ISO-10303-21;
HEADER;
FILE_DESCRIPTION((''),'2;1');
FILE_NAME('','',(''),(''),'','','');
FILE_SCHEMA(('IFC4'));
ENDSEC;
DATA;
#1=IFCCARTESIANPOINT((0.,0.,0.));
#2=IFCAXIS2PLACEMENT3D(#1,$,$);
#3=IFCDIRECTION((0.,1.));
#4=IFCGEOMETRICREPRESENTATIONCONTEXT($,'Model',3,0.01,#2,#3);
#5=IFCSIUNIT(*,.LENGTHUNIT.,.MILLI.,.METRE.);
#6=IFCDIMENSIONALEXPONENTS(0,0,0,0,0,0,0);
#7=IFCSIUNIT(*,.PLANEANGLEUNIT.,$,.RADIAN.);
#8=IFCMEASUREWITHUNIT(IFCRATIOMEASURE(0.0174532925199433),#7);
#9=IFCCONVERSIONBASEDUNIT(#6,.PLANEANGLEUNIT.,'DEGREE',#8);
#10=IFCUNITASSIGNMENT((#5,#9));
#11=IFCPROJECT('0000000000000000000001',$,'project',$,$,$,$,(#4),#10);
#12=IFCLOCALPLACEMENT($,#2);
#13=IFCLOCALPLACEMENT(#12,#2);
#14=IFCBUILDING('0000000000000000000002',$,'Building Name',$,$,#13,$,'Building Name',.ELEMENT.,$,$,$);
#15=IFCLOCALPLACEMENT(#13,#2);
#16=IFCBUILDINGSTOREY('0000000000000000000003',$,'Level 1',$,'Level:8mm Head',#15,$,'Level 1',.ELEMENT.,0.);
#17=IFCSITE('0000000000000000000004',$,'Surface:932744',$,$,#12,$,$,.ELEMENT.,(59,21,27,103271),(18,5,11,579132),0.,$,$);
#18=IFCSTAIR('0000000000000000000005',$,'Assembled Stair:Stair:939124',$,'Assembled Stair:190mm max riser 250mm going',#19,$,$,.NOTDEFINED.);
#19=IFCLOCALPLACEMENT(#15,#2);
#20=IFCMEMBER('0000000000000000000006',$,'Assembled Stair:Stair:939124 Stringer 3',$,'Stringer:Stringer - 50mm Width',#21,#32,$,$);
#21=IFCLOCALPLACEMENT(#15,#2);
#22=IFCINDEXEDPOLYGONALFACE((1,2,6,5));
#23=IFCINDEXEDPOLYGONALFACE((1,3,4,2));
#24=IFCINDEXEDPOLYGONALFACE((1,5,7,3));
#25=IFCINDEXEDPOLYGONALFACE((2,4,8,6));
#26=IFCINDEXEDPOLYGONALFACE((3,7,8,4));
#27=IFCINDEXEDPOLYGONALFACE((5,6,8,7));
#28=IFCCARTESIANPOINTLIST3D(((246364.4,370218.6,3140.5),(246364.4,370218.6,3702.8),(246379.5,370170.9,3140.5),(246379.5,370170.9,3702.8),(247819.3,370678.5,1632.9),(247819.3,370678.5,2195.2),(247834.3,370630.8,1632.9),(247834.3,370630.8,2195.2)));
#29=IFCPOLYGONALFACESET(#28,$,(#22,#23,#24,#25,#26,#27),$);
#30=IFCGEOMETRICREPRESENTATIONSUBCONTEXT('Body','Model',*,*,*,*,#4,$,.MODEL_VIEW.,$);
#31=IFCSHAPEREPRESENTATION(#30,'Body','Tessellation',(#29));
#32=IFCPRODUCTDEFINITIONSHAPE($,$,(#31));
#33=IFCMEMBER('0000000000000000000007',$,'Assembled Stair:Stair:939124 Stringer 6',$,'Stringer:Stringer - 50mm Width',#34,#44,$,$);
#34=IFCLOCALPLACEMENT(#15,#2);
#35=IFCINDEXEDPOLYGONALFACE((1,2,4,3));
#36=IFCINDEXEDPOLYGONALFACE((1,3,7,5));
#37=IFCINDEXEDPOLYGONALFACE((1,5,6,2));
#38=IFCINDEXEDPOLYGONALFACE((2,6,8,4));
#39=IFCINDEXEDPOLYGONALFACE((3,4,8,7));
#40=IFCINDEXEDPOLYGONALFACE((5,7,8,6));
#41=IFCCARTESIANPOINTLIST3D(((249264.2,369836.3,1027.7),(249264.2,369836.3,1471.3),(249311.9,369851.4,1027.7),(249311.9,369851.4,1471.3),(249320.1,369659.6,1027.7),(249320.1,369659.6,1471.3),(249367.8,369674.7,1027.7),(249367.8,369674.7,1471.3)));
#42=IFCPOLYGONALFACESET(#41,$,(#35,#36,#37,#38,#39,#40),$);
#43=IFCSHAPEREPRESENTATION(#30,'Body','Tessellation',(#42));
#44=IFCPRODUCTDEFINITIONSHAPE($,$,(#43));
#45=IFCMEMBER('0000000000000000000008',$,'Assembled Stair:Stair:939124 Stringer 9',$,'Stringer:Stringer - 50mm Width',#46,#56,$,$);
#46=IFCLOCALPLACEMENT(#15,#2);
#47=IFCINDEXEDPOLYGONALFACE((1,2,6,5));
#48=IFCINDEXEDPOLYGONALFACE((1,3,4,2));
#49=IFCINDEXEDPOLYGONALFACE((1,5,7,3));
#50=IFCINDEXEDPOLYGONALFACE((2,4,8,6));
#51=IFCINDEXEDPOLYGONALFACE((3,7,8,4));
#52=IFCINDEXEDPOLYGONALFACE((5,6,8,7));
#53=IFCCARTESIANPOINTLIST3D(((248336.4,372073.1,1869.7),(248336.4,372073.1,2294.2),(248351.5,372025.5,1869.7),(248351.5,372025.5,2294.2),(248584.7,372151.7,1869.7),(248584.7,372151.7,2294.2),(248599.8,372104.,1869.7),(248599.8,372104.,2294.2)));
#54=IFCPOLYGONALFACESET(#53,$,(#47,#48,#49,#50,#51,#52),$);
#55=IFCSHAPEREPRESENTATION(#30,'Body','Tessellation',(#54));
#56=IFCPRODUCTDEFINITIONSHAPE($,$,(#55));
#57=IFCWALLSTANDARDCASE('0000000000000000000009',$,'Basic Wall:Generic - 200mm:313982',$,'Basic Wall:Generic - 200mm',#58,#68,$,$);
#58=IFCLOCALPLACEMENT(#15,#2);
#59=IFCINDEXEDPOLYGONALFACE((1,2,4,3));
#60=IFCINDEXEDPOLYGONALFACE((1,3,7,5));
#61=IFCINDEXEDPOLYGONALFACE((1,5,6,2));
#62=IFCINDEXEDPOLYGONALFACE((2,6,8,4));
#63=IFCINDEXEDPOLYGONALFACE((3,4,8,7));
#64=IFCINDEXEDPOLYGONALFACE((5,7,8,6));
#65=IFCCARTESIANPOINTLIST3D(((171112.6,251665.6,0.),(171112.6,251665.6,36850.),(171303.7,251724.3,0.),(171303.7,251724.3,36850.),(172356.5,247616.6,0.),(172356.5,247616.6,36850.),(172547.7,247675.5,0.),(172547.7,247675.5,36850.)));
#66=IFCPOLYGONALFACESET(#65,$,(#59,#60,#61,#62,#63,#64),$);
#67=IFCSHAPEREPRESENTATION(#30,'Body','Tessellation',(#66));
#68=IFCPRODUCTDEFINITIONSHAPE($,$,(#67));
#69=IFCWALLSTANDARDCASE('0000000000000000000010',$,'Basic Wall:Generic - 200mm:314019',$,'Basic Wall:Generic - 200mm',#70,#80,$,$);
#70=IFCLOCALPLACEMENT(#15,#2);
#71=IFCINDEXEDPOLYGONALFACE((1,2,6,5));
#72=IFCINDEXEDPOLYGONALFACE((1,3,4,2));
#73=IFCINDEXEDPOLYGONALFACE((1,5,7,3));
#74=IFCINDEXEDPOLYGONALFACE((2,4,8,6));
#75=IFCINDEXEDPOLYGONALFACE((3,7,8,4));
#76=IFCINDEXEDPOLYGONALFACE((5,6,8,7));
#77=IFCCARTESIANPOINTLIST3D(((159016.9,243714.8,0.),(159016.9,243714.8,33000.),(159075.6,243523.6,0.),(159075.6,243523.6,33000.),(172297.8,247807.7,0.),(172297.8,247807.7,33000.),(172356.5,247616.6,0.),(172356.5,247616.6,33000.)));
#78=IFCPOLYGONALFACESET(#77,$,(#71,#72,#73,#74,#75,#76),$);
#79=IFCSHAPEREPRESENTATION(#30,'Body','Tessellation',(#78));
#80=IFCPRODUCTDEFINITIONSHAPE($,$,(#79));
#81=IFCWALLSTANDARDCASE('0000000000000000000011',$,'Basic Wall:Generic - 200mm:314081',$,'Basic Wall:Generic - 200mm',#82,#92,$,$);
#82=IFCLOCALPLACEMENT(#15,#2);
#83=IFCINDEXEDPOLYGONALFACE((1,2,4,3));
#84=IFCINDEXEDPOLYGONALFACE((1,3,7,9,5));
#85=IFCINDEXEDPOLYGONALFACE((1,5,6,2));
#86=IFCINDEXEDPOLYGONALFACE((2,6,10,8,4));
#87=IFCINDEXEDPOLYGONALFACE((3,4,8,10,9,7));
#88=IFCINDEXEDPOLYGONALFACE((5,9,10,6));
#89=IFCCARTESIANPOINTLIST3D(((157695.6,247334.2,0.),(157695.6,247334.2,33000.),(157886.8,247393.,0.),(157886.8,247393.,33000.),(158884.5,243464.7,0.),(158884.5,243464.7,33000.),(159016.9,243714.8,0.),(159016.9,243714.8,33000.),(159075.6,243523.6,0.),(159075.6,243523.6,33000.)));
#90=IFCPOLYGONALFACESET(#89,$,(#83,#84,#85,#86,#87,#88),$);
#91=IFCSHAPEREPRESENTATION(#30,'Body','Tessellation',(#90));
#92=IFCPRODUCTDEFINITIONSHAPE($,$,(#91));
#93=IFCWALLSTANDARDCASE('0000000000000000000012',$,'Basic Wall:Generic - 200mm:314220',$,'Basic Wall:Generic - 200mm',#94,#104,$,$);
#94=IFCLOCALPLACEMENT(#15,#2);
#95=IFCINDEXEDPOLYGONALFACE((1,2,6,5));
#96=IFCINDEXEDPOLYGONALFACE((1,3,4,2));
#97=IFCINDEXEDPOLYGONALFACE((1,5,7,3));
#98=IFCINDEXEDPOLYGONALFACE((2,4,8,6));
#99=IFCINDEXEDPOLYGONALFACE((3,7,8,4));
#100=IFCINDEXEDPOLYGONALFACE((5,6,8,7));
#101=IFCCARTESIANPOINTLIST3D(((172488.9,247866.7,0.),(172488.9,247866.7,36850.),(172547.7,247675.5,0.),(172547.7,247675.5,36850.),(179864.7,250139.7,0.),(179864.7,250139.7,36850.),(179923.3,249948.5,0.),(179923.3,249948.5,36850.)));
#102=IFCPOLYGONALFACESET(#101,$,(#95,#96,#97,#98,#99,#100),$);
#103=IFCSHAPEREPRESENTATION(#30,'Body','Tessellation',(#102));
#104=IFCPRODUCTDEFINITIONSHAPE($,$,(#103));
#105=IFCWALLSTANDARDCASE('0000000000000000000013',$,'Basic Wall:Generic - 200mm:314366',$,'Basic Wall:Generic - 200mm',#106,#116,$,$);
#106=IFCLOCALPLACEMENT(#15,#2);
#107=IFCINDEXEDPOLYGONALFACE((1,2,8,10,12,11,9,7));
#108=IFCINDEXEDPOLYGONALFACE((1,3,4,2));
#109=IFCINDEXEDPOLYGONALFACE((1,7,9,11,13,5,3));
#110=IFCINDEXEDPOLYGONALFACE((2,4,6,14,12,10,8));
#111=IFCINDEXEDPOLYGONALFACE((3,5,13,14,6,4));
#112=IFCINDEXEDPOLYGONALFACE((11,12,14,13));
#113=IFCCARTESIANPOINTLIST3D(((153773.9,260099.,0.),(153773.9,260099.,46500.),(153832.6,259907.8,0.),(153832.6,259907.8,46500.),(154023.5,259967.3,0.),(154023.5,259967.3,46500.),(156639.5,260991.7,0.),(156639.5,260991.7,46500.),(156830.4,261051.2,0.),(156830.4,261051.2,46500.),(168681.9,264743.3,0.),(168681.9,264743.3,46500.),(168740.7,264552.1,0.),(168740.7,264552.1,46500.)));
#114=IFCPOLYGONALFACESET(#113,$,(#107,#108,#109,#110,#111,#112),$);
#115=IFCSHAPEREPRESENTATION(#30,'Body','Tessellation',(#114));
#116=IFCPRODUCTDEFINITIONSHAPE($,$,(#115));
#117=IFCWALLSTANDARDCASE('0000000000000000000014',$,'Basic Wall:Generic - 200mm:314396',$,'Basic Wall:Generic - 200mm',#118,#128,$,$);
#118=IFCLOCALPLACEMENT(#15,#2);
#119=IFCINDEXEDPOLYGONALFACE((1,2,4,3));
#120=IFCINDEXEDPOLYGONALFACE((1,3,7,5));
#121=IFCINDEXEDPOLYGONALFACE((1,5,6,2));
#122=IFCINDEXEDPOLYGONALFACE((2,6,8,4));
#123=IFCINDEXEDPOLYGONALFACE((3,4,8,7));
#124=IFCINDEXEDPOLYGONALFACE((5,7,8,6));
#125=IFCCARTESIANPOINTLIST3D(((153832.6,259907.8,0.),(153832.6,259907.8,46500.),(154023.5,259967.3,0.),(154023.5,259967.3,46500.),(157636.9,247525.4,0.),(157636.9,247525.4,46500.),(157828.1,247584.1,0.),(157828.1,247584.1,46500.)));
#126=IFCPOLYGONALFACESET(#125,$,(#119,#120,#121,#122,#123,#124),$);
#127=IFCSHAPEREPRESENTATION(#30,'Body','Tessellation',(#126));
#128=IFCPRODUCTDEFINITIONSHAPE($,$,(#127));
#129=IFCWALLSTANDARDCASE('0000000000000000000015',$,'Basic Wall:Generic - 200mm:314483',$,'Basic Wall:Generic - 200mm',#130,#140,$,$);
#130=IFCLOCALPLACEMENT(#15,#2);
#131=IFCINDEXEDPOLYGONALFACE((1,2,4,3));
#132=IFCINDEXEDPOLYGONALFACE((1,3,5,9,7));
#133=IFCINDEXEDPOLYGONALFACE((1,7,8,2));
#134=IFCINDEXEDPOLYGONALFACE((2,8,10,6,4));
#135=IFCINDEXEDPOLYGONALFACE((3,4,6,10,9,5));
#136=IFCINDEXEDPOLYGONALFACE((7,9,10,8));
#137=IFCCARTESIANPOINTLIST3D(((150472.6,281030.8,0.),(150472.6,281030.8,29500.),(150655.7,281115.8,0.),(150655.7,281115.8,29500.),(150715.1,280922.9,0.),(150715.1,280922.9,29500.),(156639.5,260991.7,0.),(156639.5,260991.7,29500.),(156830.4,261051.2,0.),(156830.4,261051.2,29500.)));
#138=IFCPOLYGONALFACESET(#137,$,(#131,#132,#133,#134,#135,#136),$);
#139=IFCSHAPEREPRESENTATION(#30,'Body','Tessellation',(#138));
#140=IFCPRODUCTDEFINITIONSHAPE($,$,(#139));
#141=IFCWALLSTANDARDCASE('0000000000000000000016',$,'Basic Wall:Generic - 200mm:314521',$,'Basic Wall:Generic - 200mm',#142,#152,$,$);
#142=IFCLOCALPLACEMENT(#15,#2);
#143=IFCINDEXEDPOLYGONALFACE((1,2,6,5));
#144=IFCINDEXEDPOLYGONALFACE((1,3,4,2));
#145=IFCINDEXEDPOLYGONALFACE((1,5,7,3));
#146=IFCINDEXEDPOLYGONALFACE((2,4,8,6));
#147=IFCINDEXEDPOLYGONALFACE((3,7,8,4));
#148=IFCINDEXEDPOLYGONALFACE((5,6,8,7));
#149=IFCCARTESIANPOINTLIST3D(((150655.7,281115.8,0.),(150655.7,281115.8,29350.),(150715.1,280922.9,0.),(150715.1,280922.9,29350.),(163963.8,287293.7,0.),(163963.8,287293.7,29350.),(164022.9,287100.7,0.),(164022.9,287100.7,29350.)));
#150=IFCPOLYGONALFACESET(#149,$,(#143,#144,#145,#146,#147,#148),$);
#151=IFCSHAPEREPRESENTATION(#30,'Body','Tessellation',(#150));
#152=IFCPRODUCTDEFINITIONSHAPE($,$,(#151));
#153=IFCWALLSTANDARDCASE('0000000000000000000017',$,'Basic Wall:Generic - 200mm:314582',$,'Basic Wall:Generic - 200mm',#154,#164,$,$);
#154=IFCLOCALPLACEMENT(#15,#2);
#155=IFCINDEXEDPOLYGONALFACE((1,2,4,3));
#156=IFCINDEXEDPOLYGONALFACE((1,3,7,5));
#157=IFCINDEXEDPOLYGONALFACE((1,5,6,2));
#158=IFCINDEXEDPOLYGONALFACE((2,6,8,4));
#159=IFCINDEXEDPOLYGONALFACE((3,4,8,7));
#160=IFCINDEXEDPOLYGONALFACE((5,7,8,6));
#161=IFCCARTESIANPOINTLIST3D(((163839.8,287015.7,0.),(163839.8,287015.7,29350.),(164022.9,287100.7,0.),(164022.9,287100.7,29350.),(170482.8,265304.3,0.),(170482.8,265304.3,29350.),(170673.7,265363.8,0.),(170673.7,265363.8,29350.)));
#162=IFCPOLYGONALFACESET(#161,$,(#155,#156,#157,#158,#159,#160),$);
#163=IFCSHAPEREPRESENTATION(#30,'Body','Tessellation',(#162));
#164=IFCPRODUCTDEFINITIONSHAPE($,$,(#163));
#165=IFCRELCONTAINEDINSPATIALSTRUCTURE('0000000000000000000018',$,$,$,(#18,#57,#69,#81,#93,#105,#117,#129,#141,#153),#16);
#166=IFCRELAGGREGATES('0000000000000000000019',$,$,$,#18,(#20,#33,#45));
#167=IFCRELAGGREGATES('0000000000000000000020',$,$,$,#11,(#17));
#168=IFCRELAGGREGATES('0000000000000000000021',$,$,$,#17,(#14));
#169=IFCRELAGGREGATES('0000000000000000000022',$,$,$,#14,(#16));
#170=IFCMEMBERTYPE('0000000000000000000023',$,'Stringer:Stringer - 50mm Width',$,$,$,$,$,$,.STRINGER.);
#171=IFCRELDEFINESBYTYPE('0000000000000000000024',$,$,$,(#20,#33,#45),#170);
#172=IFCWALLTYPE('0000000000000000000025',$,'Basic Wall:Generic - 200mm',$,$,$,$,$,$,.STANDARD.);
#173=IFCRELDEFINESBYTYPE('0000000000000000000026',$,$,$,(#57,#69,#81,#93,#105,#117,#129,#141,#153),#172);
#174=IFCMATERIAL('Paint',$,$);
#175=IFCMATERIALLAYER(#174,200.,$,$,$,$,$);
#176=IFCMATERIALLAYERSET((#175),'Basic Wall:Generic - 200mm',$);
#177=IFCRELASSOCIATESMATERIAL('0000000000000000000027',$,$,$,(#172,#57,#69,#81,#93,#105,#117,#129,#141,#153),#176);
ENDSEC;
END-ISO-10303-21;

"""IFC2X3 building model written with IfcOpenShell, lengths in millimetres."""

from ifc_helpers import new_model, entity, si_unit, converted_unit, direction, frame, frame_2d, origin, place, context, subcontext, project, spatial, polyline, rectangle, outline, extrude, clip, bounded_halfspace, material, layer, layer_set, layer_usage, type_object, element, aggregate, save


model = new_model("IFC2X3")

# Units and contexts
model_context = context("Model", 3, precision=0.01, world=origin(), true_north=direction((0.0, 1.0)))
body_context = subcontext(model_context, "Body", "Model", "MODEL_VIEW")
ifc_project = project(units=[si_unit("LENGTHUNIT", "METRE", prefix="MILLI"), converted_unit("PLANEANGLEUNIT", "DEGREE", entity("IfcRatioMeasure", 0.0174532925199433), si_unit("PLANEANGLEUNIT", "RADIAN"), dimensions=[0, 0, 0, 0, 0, 0, 0])], contexts=[model_context])

# Site, building, storey
site_placement = place(None, origin())
site = spatial("IfcSite", under=ifc_project, at=site_placement, Name="Surface:932744", CompositionType="ELEMENT", RefLatitude=(59, 21, 27, 103271), RefLongitude=(18, 5, 11, 579132), RefElevation=0.0)
building_placement = place(site_placement, origin())
building = spatial("IfcBuilding", under=site, at=building_placement, Name="Building Name", LongName="Building Name", CompositionType="ELEMENT")
storey_placement = place(building_placement, origin())
storey = spatial("IfcBuildingStorey", under=building, at=storey_placement, Name="Level 1", ObjectType="Level:8mm Head", LongName="Level 1", CompositionType="ELEMENT", Elevation=0.0)

# Stair, members
stair_placement = place(building_placement, origin())
stair = element("IfcStair", 1, at=stair_placement, inside=storey, Name="Assembled Stair:Stair:939124", ObjectType="Assembled Stair:190mm max riser 250mm going", ShapeType="NOTDEFINED")
member_type = type_object("IfcMemberType", Name="Stringer:Stringer - 50mm Width", PredefinedType="STRINGER")
member_1_placement = place(stair_placement, origin())
member_1 = element("IfcMember", 2, at=member_1_placement, type_object=member_type, Name="Assembled Stair:Stair:939124 Stringer 3", ObjectType="Stringer:Stringer - 50mm Width", context=body_context, shape_type="SweptSolid", body=[
    extrude(outline(polyline([(-1270.1, -200.0), (874.9, -200.0), (1270.1, 200.0), (-874.9, 200.0), (-1270.1, -200.0)])), frame((247106.9, 370400.9, 2667.8), z_axis=(-0.301424, 0.95349, 0.0), x_axis=(-0.678262, -0.214417, 0.702841)), (0.0, 0.0, 1.0), 50.0),
])
member_2_placement = place(stair_placement, origin())
member_2 = element("IfcMember", 3, at=member_2_placement, type_object=member_type, Name="Assembled Stair:Stair:939124 Stringer 6", ObjectType="Stringer:Stringer - 50mm Width", context=body_context, shape_type="SweptSolid", body=[
    extrude(rectangle(XDim=185.4, YDim=50.0, at=frame_2d((0.0, 0.0), x_axis=(1.0, 0.0))), frame((249316.0, 369755.5, 1027.7), z_axis=(0.0, 0.0, 1.0), x_axis=(-0.301424, 0.95349, 0.0)), (0.0, 0.0, 1.0), 443.6),
])
member_3_placement = place(stair_placement, origin())
member_3 = element("IfcMember", 4, at=member_3_placement, type_object=member_type, Name="Assembled Stair:Stair:939124 Stringer 9", ObjectType="Stringer:Stringer - 50mm Width", context=body_context, shape_type="SweptSolid", body=[
    extrude(rectangle(XDim=260.5, YDim=50.0, at=frame_2d((0.0, 0.0), x_axis=(1.0, 0.0))), frame((248468.1, 372088.6, 1869.7), z_axis=(0.0, 0.0, 1.0), x_axis=(-0.95349, -0.301424, 0.0)), (0.0, 0.0, 1.0), 424.5),
])

# Walls
ifc_material_1 = material(Name="Paint")
ifc_layer_1 = layer(ifc_material_1, 200.0)
ifc_layer_set_1 = layer_set([ifc_layer_1], Name="Basic Wall:Generic - 200mm")
wall_type = type_object("IfcWallType", Name="Basic Wall:Generic - 200mm", PredefinedType="STANDARD", material=ifc_layer_set_1)
ifc_layer_usage_1 = layer_usage(ifc_layer_set_1, "AXIS2", "NEGATIVE", 100.0)
wall_1_placement = place(storey_placement, frame((171208.1, 251694.9, 0.0), z_axis=(0.0, 0.0, 1.0), x_axis=(0.293685, -0.955902, 0.0)))
element("IfcWallStandardCase", 5, at=wall_1_placement, inside=storey, type_object=wall_type, material=ifc_layer_usage_1, Name="Basic Wall:Generic - 200mm:313982", ObjectType="Basic Wall:Generic - 200mm", context=body_context, shape_type="Clipping", body=[
    clip(extrude(outline(polyline([(4235.8, -100.0), (4235.6, 100.0), (4035.6, 100.0), (200.0, 100.0), (0.0, 100.0), (0.0, -100.0), (200.0, -100.0), (4035.8, -100.0), (4235.8, -100.0)])), origin(), (0.0, 0.0, 1.0), 36850.0), bounded_halfspace(frame((0.0, -100.0, 36850.0), z_axis=(0.0, 0.0, -1.0), x_axis=(-1.0, 0.0, 0.0)), True, frame((0.0, -100.0, 36850.0), z_axis=(0.0, 0.0, -1.0), x_axis=(-1.0, 0.0, 0.0)), polyline([(0.0, 0.0), (0.0, 200.0), (-200.0, 200.0), (-4035.6, 200.0), (-4235.6, 200.0), (-4235.8, 0.0), (0.0, 0.0)]))),
])
ifc_layer_usage_2 = layer_usage(ifc_layer_set_1, "AXIS2", "NEGATIVE", 100.0)
wall_2_placement = place(storey_placement, frame((159046.2, 243619.2, 0.0), z_axis=(0.0, 0.0, 1.0), x_axis=(0.955647, 0.294515, 0.0)))
element("IfcWallStandardCase", 6, at=wall_2_placement, inside=storey, type_object=wall_type, material=ifc_layer_usage_2, Name="Basic Wall:Generic - 200mm:314019", ObjectType="Basic Wall:Generic - 200mm", context=body_context, shape_type="SweptSolid", body=[
    extrude(outline(polyline([(13897.3, -100.0), (13897.5, 100.0), (0.2, 100.0), (0.0, -100.0), (13897.3, -100.0)])), origin(), (0.0, 0.0, 1.0), 33000.0),
])
ifc_layer_usage_3 = layer_usage(ifc_layer_set_1, "AXIS2", "NEGATIVE", 100.0)
wall_3_placement = place(storey_placement, frame((157791.2, 247363.6, 0.0), z_axis=(0.0, 0.0, 1.0), x_axis=(0.293685, -0.955902, 0.0)))
element("IfcWallStandardCase", 7, at=wall_3_placement, inside=storey, type_object=wall_type, material=ifc_layer_usage_3, Name="Basic Wall:Generic - 200mm:314081", ObjectType="Basic Wall:Generic - 200mm", context=body_context, shape_type="SweptSolid", body=[
    extrude(outline(polyline([(4048.0, -100.0), (4047.9, 100.0), (3847.9, 100.0), (0.0, 100.0), (0.0, -100.0), (4048.0, -100.0)])), origin(), (0.0, 0.0, 1.0), 33000.0),
])
ifc_layer_usage_4 = layer_usage(ifc_layer_set_1, "AXIS2", "NEGATIVE", 100.0)
wall_4_placement = place(storey_placement, frame((172518.2, 247771.0, 0.0), z_axis=(0.0, 0.0, 1.0), x_axis=(0.955647, 0.294515, 0.0)))
element("IfcWallStandardCase", 8, at=wall_4_placement, inside=storey, type_object=wall_type, material=ifc_layer_usage_4, Name="Basic Wall:Generic - 200mm:314220", ObjectType="Basic Wall:Generic - 200mm", context=body_context, shape_type="Clipping", body=[
    clip(extrude(outline(polyline([(7717.9, -100.0), (7718.2, 100.0), (0.2, 100.0), (0.0, -100.0), (7717.9, -100.0)])), origin(), (0.0, 0.0, 1.0), 36850.0), bounded_halfspace(frame((0.0, -100.0, 36850.0), z_axis=(0.0, 0.0, -1.0), x_axis=(0.000869, 1.0, 0.0)), True, frame((0.0, -100.0, 36850.0), z_axis=(0.0, 0.0, -1.0), x_axis=(0.000869, 1.0, 0.0)), polyline([(0.0, 0.0), (200.0, 0.0), (206.7, 7718.1), (6.7, 7717.9), (0.0, 0.0)]))),
])
ifc_layer_usage_5 = layer_usage(ifc_layer_set_1, "AXIS2", "NEGATIVE", 100.0)
wall_5_placement = place(storey_placement, frame((168711.7, 264647.9, 0.0), z_axis=(0.0, 0.0, 1.0), x_axis=(-0.954743, -0.297431, 0.0)))
element("IfcWallStandardCase", 9, at=wall_5_placement, inside=storey, type_object=wall_type, material=ifc_layer_usage_5, Name="Basic Wall:Generic - 200mm:314366", ObjectType="Basic Wall:Generic - 200mm", context=body_context, shape_type="SweptSolid", body=[
    extrude(outline(polyline([(15614.7, -100.0), (15615.5, 100.0), (15415.5, 100.0), (0.8, 100.0), (0.0, -100.0), (12413.3, -100.0), (12613.3, -100.0), (15614.7, -100.0)])), origin(), (0.0, 0.0, 1.0), 46500.0),
])
ifc_layer_usage_6 = layer_usage(ifc_layer_set_1, "AXIS2", "NEGATIVE", 100.0)
wall_6_placement = place(storey_placement, frame((153928.0, 259938.0, 0.0), z_axis=(0.0, 0.0, 1.0), x_axis=(0.293685, -0.955902, 0.0)))
element("IfcWallStandardCase", 10, at=wall_6_placement, inside=storey, type_object=wall_type, material=ifc_layer_usage_6, Name="Basic Wall:Generic - 200mm:314396", ObjectType="Basic Wall:Generic - 200mm", context=body_context, shape_type="SweptSolid", body=[
    extrude(outline(polyline([(12954.5, -100.0), (12954.5, 100.0), (0.0, 100.0), (0.8, -100.0), (12954.5, -100.0)])), origin(), (0.0, 0.0, 1.0), 46500.0),
])
ifc_layer_usage_7 = layer_usage(ifc_layer_set_1, "AXIS2", "NEGATIVE", 100.0)
wall_7_placement = place(storey_placement, frame((156735.0, 261021.2, 0.0), z_axis=(0.0, 0.0, 1.0), x_axis=(-0.294128, 0.955766, 0.0)))
element("IfcWallStandardCase", 11, at=wall_7_placement, inside=storey, type_object=wall_type, material=ifc_layer_usage_7, Name="Basic Wall:Generic - 200mm:314483", ObjectType="Basic Wall:Generic - 200mm", context=body_context, shape_type="SweptSolid", body=[
    extrude(outline(polyline([(20993.9, -100.0), (20966.5, 100.0), (0.0, 100.0), (0.7, -100.0), (20792.0, -100.0), (20993.9, -100.0)])), origin(), (0.0, 0.0, 1.0), 29500.0),
])
ifc_layer_usage_8 = layer_usage(ifc_layer_set_1, "AXIS2", "NEGATIVE", 100.0)
wall_8_placement = place(storey_placement, frame((150673.0, 281013.6, 0.0), z_axis=(0.0, 0.0, 1.0), x_axis=(0.907031, 0.421064, 0.0)))
element("IfcWallStandardCase", 12, at=wall_8_placement, inside=storey, type_object=wall_type, material=ifc_layer_usage_8, Name="Basic Wall:Generic - 200mm:314521", ObjectType="Basic Wall:Generic - 200mm", context=body_context, shape_type="Clipping", body=[
    clip(extrude(outline(polyline([(14671.8, -100.0), (14699.5, 100.0), (27.4, 100.0), (0.0, -100.0), (14469.9, -100.0), (14671.8, -100.0)])), origin(), (0.0, 0.0, 1.0), 29350.0), bounded_halfspace(frame((0.0, -100.0, 29350.0), z_axis=(0.0, 0.0, -1.0), x_axis=(1.0, 0.0, 0.0)), True, frame((0.0, -100.0, 29350.0), z_axis=(0.0, 0.0, -1.0), x_axis=(1.0, 0.0, 0.0)), polyline([(0.0, 0.0), (27.4, -200.0), (14699.5, -200.0), (14671.8, 0.0), (0.0, 0.0)]))),
])
ifc_layer_usage_9 = layer_usage(ifc_layer_set_1, "AXIS2", "NEGATIVE", 100.0)
wall_9_placement = place(storey_placement, frame((163927.3, 287071.4, 0.0), z_axis=(0.0, 0.0, 1.0), x_axis=(0.292582, -0.95624, 0.0)))
element("IfcWallStandardCase", 13, at=wall_9_placement, inside=storey, type_object=wall_type, material=ifc_layer_usage_9, Name="Basic Wall:Generic - 200mm:314582", ObjectType="Basic Wall:Generic - 200mm", context=body_context, shape_type="Clipping", body=[
    clip(extrude(outline(polyline([(22732.6, -100.0), (22731.6, 100.0), (0.0, 100.0), (27.7, -100.0), (22732.6, -100.0)])), origin(), (0.0, 0.0, 1.0), 29350.0), bounded_halfspace(frame((27.7, -100.0, 29350.0), z_axis=(0.0, 0.0, -1.0), x_axis=(-0.137257, 0.990535, 0.0)), True, frame((27.7, -100.0, 29350.0), z_axis=(0.0, 0.0, -1.0), x_axis=(-0.137257, 0.990535, 0.0)), polyline([(0.0, 0.0), (201.9, 0.0), (-2918.2, 22516.4), (-3116.4, 22490.0), (0.0, 0.0)]))),
])

aggregate(stair, [member_1, member_2, member_3])

save(model, "model.ifc")
